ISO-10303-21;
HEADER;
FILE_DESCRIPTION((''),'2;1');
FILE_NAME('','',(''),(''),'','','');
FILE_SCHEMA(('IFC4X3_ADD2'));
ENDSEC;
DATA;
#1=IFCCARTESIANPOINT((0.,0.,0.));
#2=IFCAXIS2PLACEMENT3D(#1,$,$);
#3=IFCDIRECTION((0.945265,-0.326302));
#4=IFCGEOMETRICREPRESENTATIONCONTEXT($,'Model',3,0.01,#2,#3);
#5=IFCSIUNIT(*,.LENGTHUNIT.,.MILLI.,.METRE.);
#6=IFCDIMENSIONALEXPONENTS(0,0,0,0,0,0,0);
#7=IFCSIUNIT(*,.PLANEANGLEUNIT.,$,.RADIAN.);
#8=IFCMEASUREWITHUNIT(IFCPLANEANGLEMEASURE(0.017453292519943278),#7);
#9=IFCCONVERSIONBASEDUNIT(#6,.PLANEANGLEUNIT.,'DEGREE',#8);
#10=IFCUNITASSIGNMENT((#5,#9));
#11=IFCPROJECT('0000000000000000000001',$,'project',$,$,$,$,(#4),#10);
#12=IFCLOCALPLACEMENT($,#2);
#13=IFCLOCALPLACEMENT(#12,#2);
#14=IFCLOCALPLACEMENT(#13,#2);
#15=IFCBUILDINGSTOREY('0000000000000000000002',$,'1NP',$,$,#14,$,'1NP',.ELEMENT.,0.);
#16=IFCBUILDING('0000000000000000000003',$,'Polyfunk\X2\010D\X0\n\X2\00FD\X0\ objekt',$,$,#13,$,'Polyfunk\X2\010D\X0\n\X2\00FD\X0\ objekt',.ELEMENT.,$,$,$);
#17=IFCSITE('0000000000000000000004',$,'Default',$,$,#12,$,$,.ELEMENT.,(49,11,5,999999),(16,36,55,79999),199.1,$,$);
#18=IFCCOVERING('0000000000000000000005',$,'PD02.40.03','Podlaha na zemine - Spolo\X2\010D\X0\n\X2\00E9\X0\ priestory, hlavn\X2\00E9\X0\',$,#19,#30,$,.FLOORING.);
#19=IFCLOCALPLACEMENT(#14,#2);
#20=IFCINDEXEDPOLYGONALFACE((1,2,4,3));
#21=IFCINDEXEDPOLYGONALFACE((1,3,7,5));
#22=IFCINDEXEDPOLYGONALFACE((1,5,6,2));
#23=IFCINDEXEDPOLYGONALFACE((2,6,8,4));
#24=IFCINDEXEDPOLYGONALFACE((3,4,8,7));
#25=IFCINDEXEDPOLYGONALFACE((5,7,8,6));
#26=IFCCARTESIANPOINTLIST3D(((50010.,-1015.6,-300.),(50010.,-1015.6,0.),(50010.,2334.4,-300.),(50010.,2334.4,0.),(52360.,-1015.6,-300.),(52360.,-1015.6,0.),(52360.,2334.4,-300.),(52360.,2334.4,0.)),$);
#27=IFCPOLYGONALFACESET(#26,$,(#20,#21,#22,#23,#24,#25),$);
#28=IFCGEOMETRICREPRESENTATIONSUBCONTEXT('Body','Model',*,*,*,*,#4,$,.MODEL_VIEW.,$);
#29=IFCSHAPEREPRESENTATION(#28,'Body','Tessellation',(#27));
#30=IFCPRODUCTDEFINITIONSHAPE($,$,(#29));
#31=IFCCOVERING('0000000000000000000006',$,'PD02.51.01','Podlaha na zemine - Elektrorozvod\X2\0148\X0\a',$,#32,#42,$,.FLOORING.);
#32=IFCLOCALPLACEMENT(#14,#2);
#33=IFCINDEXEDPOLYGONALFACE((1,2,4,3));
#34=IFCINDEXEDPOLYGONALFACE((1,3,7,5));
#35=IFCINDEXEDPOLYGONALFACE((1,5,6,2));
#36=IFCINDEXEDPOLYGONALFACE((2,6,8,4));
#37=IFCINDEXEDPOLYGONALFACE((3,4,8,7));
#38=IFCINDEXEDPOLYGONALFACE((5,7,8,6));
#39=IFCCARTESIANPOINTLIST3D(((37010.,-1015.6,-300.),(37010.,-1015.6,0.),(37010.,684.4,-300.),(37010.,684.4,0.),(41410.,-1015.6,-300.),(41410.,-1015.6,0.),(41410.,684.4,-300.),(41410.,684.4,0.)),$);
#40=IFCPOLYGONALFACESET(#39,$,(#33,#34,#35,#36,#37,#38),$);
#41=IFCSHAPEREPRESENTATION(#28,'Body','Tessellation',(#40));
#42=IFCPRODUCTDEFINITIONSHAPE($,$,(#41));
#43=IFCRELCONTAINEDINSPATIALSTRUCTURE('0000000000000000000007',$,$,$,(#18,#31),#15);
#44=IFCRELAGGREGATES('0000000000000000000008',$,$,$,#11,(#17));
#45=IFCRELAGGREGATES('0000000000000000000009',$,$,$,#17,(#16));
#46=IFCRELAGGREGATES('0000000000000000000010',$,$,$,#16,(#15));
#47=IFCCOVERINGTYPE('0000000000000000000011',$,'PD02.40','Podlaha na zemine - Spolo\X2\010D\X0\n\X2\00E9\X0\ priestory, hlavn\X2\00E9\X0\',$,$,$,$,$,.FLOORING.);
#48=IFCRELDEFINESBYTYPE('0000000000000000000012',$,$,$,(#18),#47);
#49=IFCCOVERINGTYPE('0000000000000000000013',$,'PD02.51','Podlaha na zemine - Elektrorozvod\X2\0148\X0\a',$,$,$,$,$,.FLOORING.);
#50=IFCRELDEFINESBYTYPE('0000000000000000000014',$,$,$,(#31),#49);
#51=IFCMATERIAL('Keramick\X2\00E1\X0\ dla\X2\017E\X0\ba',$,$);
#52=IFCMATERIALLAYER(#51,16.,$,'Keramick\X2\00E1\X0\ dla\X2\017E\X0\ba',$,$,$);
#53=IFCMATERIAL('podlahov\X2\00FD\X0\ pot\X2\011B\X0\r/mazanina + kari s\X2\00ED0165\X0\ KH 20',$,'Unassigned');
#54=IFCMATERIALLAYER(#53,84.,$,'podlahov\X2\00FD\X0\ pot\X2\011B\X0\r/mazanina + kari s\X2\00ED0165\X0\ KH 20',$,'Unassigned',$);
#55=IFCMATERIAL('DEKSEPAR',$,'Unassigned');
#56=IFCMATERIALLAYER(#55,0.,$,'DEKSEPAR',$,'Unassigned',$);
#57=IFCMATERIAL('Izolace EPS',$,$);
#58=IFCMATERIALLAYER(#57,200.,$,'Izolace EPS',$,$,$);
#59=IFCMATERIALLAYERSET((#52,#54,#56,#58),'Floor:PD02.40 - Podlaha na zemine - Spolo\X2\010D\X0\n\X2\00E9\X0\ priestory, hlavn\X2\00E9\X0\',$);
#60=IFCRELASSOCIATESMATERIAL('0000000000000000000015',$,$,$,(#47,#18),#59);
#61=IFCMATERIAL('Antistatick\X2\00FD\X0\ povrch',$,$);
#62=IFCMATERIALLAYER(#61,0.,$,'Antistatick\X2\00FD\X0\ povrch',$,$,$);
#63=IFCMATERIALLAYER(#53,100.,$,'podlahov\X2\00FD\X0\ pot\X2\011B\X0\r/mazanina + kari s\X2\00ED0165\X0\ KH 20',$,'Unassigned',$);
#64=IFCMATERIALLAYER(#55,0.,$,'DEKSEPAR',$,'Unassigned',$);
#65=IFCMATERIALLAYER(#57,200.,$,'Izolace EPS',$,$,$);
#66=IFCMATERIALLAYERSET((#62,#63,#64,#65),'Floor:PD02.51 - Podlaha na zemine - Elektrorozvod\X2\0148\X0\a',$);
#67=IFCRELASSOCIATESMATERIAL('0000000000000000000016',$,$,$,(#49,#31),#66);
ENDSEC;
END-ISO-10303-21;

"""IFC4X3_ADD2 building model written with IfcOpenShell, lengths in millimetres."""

from ifc_helpers import new_model, entity, si_unit, converted_unit, direction, frame, frame_2d, origin, place, context, subcontext, project, spatial, rectangle, extrude, material, layer, layer_set, layer_usage, type_object, element, save


model = new_model("IFC4X3_ADD2")

# Units and contexts
model_context = context("Model", 3, precision=0.01, world=origin(), true_north=direction((0.945265, -0.326302)))
body_context = subcontext(model_context, "Body", "Model", "MODEL_VIEW")
ifc_project = project(units=[si_unit("LENGTHUNIT", "METRE", prefix="MILLI"), converted_unit("PLANEANGLEUNIT", "DEGREE", entity("IfcPlaneAngleMeasure", 0.017453292519943278), si_unit("PLANEANGLEUNIT", "RADIAN"), dimensions=[0, 0, 0, 0, 0, 0, 0])], contexts=[model_context])

# Site, building, storey
site_placement = place(None, origin())
site = spatial("IfcSite", under=ifc_project, at=site_placement, Name="Default", CompositionType="ELEMENT", RefLatitude=(49, 11, 5, 999999), RefLongitude=(16, 36, 55, 79999), RefElevation=199.1)
building_placement = place(site_placement, origin())
building = spatial("IfcBuilding", under=site, at=building_placement, Name="Polyfunkčný objekt", LongName="Polyfunkčný objekt", CompositionType="ELEMENT")
storey_placement = place(building_placement, origin())
storey = spatial("IfcBuildingStorey", under=building, at=storey_placement, Name="1NP", LongName="1NP", CompositionType="ELEMENT", Elevation=0.0)

# Shared definitions
ifc_material_1 = material(Name="podlahový potěr/mazanina + kari síť KH 20", Category="Unassigned")
ifc_material_2 = material(Name="DEKSEPAR", Category="Unassigned")
ifc_material_3 = material(Name="Izolace EPS")
ifc_material_4 = material(Name="Keramická dlažba")

# Coverings
ifc_layer_1 = layer(ifc_material_4, 16.0, Name="Keramická dlažba")
ifc_layer_2 = layer(ifc_material_1, 84.0, Name="podlahový potěr/mazanina + kari síť KH 20", Category="Unassigned")
ifc_layer_3 = layer(ifc_material_2, 0.0, Name="DEKSEPAR", Category="Unassigned")
ifc_layer_4 = layer(ifc_material_3, 200.0, Name="Izolace EPS")
ifc_layer_set_1 = layer_set([ifc_layer_1, ifc_layer_2, ifc_layer_3, ifc_layer_4], Name="Floor:PD02.40 - Podlaha na zemine - Spoločné priestory, hlavné")
covering_type_1 = type_object("IfcCoveringType", Name="PD02.40", Description="Podlaha na zemine - Spoločné priestory, hlavné", PredefinedType="FLOORING", material=ifc_layer_set_1)
ifc_layer_usage_1 = layer_usage(ifc_layer_set_1, "AXIS3", "POSITIVE", 0.0)
covering_1_placement = place(storey_placement, origin())
element("IfcCovering", 1, at=covering_1_placement, inside=storey, type_object=covering_type_1, material=ifc_layer_usage_1, Name="PD02.40.03", Description="Podlaha na zemine - Spoločné priestory, hlavné", PredefinedType="FLOORING", context=body_context, shape_type="SweptSolid", body=[
    extrude(rectangle(XDim=3350.0, YDim=2350.0, at=frame_2d((0.0, 0.0), x_axis=(1.0, 0.0))), frame((51185.0, 659.4, 0.0), z_axis=(0.0, 0.0, -1.0), x_axis=(0.0, 1.0, 0.0)), (0.0, 0.0, 1.0), 300.0),
])
ifc_material_5 = material(Name="Antistatický povrch")
ifc_layer_5 = layer(ifc_material_5, 0.0, Name="Antistatický povrch")
ifc_layer_6 = layer(ifc_material_1, 100.0, Name="podlahový potěr/mazanina + kari síť KH 20", Category="Unassigned")
ifc_layer_7 = layer(ifc_material_2, 0.0, Name="DEKSEPAR", Category="Unassigned")
ifc_layer_8 = layer(ifc_material_3, 200.0, Name="Izolace EPS")
ifc_layer_set_2 = layer_set([ifc_layer_5, ifc_layer_6, ifc_layer_7, ifc_layer_8], Name="Floor:PD02.51 - Podlaha na zemine - Elektrorozvodňa")
ifc_layer_usage_2 = layer_usage(ifc_layer_set_2, "AXIS3", "POSITIVE", 0.0)
covering_type_2 = type_object("IfcCoveringType", Name="PD02.51", Description="Podlaha na zemine - Elektrorozvodňa", PredefinedType="FLOORING", material=ifc_layer_set_2)
covering_2_placement = place(storey_placement, origin())
element("IfcCovering", 2, at=covering_2_placement, inside=storey, type_object=covering_type_2, material=ifc_layer_usage_2, Name="PD02.51.01", Description="Podlaha na zemine - Elektrorozvodňa", PredefinedType="FLOORING", context=body_context, shape_type="SweptSolid", body=[
    extrude(rectangle(XDim=1700.0, YDim=4400.0, at=frame_2d((0.0, 0.0), x_axis=(1.0, 0.0))), frame((39210.0, -165.6, 0.0), z_axis=(0.0, 0.0, -1.0), x_axis=(0.0, 1.0, 0.0)), (0.0, 0.0, 1.0), 300.0),
])

save(model, "model.ifc")
